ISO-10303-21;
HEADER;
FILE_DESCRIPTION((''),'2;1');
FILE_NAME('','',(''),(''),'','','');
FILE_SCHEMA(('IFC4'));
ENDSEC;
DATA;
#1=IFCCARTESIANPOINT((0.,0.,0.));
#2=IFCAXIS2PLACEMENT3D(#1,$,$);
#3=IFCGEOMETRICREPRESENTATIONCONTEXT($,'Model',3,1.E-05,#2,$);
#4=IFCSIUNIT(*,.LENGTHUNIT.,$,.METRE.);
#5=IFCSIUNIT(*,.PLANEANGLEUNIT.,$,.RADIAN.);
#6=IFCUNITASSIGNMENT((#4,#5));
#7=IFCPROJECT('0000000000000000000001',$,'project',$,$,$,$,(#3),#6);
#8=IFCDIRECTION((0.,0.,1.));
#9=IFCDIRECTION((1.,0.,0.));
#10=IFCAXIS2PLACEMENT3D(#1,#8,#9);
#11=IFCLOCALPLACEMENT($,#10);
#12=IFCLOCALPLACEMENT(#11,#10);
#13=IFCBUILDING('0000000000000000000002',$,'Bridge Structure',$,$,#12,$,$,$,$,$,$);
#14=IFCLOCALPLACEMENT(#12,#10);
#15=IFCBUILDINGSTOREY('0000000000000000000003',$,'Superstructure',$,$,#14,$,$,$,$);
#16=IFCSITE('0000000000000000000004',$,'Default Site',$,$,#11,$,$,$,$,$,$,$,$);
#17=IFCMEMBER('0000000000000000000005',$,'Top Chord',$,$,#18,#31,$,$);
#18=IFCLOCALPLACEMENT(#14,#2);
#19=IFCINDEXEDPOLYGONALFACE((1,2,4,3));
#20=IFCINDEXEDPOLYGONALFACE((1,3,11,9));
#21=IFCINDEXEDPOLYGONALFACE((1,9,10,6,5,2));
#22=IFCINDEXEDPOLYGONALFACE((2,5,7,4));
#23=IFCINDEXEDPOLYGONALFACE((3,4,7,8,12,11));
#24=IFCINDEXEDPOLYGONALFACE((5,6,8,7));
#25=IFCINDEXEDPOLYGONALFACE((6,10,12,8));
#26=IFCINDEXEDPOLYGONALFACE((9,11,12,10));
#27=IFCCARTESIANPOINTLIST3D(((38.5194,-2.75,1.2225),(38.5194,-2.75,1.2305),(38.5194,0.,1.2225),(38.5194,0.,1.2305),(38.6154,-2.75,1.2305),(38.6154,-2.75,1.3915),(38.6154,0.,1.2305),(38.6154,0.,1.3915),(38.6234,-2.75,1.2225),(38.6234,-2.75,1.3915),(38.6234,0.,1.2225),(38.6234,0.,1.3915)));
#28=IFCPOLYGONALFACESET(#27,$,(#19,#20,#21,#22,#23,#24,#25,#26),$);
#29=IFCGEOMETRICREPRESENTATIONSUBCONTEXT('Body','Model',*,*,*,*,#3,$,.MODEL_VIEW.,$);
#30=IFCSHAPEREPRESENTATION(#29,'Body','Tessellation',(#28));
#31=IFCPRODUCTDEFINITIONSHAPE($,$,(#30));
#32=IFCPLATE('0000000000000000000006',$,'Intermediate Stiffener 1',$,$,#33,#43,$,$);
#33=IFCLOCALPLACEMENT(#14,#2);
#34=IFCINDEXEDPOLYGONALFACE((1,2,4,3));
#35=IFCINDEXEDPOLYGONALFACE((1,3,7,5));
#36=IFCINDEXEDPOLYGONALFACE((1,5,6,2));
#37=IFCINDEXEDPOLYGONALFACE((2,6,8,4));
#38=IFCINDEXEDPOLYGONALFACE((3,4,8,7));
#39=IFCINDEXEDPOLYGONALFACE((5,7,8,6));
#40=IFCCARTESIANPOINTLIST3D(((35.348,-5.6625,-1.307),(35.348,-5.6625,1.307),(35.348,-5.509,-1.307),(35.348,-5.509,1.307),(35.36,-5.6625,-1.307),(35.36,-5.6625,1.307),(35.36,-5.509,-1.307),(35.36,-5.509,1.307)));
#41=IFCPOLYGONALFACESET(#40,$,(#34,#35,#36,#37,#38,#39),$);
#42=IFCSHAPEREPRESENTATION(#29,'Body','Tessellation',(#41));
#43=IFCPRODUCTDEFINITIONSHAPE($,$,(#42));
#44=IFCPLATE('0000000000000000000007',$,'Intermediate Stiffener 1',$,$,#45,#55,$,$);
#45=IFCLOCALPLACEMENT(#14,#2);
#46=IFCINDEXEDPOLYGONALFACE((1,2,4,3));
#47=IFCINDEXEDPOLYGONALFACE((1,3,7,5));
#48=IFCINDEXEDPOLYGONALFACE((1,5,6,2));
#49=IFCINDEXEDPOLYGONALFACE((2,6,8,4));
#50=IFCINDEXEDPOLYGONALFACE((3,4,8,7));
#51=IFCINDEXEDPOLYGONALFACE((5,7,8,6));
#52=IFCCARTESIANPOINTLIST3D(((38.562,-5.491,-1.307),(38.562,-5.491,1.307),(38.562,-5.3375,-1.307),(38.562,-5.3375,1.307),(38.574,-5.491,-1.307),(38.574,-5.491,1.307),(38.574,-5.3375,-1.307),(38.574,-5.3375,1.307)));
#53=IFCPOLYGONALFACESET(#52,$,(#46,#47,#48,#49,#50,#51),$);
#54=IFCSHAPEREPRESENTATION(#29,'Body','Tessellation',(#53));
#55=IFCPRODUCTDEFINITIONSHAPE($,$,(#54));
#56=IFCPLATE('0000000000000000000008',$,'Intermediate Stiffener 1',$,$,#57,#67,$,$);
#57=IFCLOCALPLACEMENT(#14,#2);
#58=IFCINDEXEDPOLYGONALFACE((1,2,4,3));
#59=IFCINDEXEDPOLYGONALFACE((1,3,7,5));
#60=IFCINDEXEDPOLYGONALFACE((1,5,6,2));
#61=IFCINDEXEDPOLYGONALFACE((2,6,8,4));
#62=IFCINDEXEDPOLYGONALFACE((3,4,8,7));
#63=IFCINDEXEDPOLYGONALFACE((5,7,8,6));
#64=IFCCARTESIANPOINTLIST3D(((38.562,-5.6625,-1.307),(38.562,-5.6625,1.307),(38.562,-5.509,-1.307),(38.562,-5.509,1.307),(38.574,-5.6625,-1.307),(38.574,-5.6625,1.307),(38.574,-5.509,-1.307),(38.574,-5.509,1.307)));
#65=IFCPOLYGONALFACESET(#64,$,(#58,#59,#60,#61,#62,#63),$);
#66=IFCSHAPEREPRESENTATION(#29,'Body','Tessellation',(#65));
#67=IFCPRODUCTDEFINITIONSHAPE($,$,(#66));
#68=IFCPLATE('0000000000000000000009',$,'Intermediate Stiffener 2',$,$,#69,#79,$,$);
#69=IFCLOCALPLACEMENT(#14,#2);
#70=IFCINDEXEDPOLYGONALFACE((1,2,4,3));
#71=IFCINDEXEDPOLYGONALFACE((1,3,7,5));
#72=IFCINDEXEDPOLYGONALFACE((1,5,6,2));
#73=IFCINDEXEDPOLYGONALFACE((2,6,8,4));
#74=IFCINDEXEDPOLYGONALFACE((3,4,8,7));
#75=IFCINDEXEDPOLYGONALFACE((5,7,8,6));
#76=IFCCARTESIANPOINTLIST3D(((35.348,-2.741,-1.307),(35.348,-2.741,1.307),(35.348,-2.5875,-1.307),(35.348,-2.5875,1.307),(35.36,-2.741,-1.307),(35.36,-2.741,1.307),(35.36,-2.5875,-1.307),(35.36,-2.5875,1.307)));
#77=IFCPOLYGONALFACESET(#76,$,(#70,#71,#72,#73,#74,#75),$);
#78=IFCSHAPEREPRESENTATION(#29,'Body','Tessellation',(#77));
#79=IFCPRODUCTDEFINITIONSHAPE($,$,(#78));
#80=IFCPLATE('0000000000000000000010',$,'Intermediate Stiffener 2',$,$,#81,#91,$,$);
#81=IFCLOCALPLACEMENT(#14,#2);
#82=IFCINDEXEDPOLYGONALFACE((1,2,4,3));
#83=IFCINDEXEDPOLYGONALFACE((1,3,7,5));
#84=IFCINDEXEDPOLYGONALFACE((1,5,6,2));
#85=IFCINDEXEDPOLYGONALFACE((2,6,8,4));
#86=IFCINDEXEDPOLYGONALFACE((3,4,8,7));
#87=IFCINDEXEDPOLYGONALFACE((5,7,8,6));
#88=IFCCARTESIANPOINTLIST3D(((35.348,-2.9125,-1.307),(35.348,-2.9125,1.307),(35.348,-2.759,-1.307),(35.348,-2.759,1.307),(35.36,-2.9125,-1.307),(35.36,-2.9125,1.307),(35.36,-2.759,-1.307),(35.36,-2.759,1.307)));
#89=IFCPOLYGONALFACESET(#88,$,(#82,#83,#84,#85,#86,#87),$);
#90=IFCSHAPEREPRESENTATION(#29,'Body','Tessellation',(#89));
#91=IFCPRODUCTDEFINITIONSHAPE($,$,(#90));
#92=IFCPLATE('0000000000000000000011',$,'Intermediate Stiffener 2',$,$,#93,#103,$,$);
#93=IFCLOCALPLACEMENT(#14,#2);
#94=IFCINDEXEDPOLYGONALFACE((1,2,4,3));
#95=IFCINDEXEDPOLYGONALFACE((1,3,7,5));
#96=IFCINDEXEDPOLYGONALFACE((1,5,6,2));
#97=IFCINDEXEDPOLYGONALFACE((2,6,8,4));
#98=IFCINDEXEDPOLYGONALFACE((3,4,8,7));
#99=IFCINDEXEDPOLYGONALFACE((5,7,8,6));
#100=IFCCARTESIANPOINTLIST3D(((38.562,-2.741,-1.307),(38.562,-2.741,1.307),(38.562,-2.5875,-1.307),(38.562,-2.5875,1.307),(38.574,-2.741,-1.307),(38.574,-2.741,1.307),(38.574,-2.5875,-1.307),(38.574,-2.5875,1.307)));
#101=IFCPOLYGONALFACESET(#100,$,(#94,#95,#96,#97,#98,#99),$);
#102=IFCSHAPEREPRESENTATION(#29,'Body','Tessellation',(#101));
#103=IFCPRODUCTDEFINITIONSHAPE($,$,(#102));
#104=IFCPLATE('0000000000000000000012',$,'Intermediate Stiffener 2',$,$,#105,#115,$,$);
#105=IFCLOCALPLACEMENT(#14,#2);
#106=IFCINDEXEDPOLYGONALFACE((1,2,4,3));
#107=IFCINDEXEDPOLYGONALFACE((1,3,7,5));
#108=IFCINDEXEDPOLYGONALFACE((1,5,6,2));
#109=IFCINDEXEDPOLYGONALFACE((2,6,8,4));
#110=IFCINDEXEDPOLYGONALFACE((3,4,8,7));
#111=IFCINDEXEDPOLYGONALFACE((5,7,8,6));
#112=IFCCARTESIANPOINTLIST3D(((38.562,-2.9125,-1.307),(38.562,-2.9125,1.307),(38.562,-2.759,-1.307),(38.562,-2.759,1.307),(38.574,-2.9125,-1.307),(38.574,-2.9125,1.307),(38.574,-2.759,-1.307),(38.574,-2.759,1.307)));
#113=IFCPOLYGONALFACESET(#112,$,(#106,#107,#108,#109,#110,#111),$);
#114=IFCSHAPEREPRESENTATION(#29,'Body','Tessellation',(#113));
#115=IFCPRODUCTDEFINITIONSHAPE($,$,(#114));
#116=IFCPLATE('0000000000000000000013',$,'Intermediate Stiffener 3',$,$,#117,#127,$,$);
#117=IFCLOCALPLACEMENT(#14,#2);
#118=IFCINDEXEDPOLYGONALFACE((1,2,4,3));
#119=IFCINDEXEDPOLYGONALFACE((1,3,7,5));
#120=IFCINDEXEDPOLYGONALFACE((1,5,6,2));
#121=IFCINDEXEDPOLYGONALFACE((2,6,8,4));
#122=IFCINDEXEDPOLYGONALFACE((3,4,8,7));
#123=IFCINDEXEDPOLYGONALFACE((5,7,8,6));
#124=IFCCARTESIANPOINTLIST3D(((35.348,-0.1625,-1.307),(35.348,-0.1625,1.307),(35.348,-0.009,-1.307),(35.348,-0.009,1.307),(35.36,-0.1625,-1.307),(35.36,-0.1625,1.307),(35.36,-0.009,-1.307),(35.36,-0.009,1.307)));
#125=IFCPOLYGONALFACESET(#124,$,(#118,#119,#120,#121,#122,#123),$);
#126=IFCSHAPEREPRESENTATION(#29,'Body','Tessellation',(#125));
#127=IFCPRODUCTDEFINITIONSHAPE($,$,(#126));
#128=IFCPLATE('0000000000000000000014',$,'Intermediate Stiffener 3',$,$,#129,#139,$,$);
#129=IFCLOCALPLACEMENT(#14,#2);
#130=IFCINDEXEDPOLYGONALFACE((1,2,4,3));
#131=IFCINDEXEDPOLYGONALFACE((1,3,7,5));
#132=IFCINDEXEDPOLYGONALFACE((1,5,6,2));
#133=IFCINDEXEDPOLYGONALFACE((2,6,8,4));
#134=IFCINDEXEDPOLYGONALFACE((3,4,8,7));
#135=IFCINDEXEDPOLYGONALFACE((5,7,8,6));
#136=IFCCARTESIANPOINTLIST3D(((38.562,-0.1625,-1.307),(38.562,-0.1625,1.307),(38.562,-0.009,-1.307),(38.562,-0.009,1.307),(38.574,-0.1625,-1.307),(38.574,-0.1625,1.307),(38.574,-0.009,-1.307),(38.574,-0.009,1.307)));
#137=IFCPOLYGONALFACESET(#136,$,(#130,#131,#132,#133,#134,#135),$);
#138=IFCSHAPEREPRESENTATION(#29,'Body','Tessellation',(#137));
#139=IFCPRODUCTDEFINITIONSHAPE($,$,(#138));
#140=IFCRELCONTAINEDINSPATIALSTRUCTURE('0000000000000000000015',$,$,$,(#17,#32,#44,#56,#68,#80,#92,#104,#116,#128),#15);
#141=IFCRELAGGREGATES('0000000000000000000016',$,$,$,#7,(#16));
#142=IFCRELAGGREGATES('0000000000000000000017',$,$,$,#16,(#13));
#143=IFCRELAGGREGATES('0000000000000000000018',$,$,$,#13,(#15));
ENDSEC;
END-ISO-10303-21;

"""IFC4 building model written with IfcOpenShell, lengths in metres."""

from ifc_helpers import new_model, si_unit, frame, origin, origin_with_axes, origin_2d_with_axis, place, context, subcontext, project, spatial, rectangle, l_section, extrude, element, save


model = new_model("IFC4")

# Units and contexts
model_context = context("Model", 3, precision=1e-05, world=origin())
body_context = subcontext(model_context, "Body", "Model", "MODEL_VIEW")
ifc_project = project(units=[si_unit("LENGTHUNIT", "METRE"), si_unit("PLANEANGLEUNIT", "RADIAN")], contexts=[model_context])

# Site, building, storey
site_placement = place(None, origin_with_axes())
site = spatial("IfcSite", under=ifc_project, at=site_placement, Name="Default Site")
building_placement = place(site_placement, origin_with_axes())
building = spatial("IfcBuilding", under=site, at=building_placement, Name="Bridge Structure")
storey_placement = place(building_placement, origin_with_axes())
storey = spatial("IfcBuildingStorey", under=building, at=storey_placement, Name="Superstructure")

# Member
for number, where, z_axis, x_axis, name in (
    (1, (38.5714, -2.75, 1.307), (0.0, 1.0, 0.0), (-1.0, 0.0, 0.0), "Top Chord"),
):
    element("IfcMember", number, at=place(storey_placement, frame(where, z_axis=z_axis, x_axis=x_axis)), inside=storey, Name=name, context=body_context, shape_type="SweptSolid", body=[
        extrude(l_section(Depth=0.169, Width=0.104, Thickness=0.008, at=origin_2d_with_axis()), origin_with_axes(), (0.0, 0.0, 1.0), 2.75),
    ])

# Plates
for number, where, z_axis, x_axis, name in (
    (2, (35.354, -5.5857, -1.307), (0.0, 0.0, 1.0), (1.0, 0.0, 0.0), "Intermediate Stiffener 1"),
    (3, (38.568, -5.4143, -1.307), (0.0, 0.0, 1.0), (1.0, 0.0, 0.0), "Intermediate Stiffener 1"),
    (4, (38.568, -5.5857, -1.307), (0.0, 0.0, 1.0), (1.0, 0.0, 0.0), "Intermediate Stiffener 1"),
    (5, (35.354, -2.6643, -1.307), (0.0, 0.0, 1.0), (1.0, 0.0, 0.0), "Intermediate Stiffener 2"),
    (6, (35.354, -2.8357, -1.307), (0.0, 0.0, 1.0), (1.0, 0.0, 0.0), "Intermediate Stiffener 2"),
    (7, (38.568, -2.6643, -1.307), (0.0, 0.0, 1.0), (1.0, 0.0, 0.0), "Intermediate Stiffener 2"),
    (8, (38.568, -2.8357, -1.307), (0.0, 0.0, 1.0), (1.0, 0.0, 0.0), "Intermediate Stiffener 2"),
    (9, (35.354, -0.0858, -1.307), (0.0, 0.0, 1.0), (1.0, 0.0, 0.0), "Intermediate Stiffener 3"),
    (10, (38.568, -0.0858, -1.307), (0.0, 0.0, 1.0), (1.0, 0.0, 0.0), "Intermediate Stiffener 3"),
):
    element("IfcPlate", number, at=place(storey_placement, frame(where, z_axis=z_axis, x_axis=x_axis)), inside=storey, Name=name, context=body_context, shape_type="SweptSolid", body=[
        extrude(rectangle(XDim=0.012, YDim=0.1535, at=origin_2d_with_axis()), origin_with_axes(), (0.0, 0.0, 1.0), 2.614),
    ])

save(model, "model.ifc")
